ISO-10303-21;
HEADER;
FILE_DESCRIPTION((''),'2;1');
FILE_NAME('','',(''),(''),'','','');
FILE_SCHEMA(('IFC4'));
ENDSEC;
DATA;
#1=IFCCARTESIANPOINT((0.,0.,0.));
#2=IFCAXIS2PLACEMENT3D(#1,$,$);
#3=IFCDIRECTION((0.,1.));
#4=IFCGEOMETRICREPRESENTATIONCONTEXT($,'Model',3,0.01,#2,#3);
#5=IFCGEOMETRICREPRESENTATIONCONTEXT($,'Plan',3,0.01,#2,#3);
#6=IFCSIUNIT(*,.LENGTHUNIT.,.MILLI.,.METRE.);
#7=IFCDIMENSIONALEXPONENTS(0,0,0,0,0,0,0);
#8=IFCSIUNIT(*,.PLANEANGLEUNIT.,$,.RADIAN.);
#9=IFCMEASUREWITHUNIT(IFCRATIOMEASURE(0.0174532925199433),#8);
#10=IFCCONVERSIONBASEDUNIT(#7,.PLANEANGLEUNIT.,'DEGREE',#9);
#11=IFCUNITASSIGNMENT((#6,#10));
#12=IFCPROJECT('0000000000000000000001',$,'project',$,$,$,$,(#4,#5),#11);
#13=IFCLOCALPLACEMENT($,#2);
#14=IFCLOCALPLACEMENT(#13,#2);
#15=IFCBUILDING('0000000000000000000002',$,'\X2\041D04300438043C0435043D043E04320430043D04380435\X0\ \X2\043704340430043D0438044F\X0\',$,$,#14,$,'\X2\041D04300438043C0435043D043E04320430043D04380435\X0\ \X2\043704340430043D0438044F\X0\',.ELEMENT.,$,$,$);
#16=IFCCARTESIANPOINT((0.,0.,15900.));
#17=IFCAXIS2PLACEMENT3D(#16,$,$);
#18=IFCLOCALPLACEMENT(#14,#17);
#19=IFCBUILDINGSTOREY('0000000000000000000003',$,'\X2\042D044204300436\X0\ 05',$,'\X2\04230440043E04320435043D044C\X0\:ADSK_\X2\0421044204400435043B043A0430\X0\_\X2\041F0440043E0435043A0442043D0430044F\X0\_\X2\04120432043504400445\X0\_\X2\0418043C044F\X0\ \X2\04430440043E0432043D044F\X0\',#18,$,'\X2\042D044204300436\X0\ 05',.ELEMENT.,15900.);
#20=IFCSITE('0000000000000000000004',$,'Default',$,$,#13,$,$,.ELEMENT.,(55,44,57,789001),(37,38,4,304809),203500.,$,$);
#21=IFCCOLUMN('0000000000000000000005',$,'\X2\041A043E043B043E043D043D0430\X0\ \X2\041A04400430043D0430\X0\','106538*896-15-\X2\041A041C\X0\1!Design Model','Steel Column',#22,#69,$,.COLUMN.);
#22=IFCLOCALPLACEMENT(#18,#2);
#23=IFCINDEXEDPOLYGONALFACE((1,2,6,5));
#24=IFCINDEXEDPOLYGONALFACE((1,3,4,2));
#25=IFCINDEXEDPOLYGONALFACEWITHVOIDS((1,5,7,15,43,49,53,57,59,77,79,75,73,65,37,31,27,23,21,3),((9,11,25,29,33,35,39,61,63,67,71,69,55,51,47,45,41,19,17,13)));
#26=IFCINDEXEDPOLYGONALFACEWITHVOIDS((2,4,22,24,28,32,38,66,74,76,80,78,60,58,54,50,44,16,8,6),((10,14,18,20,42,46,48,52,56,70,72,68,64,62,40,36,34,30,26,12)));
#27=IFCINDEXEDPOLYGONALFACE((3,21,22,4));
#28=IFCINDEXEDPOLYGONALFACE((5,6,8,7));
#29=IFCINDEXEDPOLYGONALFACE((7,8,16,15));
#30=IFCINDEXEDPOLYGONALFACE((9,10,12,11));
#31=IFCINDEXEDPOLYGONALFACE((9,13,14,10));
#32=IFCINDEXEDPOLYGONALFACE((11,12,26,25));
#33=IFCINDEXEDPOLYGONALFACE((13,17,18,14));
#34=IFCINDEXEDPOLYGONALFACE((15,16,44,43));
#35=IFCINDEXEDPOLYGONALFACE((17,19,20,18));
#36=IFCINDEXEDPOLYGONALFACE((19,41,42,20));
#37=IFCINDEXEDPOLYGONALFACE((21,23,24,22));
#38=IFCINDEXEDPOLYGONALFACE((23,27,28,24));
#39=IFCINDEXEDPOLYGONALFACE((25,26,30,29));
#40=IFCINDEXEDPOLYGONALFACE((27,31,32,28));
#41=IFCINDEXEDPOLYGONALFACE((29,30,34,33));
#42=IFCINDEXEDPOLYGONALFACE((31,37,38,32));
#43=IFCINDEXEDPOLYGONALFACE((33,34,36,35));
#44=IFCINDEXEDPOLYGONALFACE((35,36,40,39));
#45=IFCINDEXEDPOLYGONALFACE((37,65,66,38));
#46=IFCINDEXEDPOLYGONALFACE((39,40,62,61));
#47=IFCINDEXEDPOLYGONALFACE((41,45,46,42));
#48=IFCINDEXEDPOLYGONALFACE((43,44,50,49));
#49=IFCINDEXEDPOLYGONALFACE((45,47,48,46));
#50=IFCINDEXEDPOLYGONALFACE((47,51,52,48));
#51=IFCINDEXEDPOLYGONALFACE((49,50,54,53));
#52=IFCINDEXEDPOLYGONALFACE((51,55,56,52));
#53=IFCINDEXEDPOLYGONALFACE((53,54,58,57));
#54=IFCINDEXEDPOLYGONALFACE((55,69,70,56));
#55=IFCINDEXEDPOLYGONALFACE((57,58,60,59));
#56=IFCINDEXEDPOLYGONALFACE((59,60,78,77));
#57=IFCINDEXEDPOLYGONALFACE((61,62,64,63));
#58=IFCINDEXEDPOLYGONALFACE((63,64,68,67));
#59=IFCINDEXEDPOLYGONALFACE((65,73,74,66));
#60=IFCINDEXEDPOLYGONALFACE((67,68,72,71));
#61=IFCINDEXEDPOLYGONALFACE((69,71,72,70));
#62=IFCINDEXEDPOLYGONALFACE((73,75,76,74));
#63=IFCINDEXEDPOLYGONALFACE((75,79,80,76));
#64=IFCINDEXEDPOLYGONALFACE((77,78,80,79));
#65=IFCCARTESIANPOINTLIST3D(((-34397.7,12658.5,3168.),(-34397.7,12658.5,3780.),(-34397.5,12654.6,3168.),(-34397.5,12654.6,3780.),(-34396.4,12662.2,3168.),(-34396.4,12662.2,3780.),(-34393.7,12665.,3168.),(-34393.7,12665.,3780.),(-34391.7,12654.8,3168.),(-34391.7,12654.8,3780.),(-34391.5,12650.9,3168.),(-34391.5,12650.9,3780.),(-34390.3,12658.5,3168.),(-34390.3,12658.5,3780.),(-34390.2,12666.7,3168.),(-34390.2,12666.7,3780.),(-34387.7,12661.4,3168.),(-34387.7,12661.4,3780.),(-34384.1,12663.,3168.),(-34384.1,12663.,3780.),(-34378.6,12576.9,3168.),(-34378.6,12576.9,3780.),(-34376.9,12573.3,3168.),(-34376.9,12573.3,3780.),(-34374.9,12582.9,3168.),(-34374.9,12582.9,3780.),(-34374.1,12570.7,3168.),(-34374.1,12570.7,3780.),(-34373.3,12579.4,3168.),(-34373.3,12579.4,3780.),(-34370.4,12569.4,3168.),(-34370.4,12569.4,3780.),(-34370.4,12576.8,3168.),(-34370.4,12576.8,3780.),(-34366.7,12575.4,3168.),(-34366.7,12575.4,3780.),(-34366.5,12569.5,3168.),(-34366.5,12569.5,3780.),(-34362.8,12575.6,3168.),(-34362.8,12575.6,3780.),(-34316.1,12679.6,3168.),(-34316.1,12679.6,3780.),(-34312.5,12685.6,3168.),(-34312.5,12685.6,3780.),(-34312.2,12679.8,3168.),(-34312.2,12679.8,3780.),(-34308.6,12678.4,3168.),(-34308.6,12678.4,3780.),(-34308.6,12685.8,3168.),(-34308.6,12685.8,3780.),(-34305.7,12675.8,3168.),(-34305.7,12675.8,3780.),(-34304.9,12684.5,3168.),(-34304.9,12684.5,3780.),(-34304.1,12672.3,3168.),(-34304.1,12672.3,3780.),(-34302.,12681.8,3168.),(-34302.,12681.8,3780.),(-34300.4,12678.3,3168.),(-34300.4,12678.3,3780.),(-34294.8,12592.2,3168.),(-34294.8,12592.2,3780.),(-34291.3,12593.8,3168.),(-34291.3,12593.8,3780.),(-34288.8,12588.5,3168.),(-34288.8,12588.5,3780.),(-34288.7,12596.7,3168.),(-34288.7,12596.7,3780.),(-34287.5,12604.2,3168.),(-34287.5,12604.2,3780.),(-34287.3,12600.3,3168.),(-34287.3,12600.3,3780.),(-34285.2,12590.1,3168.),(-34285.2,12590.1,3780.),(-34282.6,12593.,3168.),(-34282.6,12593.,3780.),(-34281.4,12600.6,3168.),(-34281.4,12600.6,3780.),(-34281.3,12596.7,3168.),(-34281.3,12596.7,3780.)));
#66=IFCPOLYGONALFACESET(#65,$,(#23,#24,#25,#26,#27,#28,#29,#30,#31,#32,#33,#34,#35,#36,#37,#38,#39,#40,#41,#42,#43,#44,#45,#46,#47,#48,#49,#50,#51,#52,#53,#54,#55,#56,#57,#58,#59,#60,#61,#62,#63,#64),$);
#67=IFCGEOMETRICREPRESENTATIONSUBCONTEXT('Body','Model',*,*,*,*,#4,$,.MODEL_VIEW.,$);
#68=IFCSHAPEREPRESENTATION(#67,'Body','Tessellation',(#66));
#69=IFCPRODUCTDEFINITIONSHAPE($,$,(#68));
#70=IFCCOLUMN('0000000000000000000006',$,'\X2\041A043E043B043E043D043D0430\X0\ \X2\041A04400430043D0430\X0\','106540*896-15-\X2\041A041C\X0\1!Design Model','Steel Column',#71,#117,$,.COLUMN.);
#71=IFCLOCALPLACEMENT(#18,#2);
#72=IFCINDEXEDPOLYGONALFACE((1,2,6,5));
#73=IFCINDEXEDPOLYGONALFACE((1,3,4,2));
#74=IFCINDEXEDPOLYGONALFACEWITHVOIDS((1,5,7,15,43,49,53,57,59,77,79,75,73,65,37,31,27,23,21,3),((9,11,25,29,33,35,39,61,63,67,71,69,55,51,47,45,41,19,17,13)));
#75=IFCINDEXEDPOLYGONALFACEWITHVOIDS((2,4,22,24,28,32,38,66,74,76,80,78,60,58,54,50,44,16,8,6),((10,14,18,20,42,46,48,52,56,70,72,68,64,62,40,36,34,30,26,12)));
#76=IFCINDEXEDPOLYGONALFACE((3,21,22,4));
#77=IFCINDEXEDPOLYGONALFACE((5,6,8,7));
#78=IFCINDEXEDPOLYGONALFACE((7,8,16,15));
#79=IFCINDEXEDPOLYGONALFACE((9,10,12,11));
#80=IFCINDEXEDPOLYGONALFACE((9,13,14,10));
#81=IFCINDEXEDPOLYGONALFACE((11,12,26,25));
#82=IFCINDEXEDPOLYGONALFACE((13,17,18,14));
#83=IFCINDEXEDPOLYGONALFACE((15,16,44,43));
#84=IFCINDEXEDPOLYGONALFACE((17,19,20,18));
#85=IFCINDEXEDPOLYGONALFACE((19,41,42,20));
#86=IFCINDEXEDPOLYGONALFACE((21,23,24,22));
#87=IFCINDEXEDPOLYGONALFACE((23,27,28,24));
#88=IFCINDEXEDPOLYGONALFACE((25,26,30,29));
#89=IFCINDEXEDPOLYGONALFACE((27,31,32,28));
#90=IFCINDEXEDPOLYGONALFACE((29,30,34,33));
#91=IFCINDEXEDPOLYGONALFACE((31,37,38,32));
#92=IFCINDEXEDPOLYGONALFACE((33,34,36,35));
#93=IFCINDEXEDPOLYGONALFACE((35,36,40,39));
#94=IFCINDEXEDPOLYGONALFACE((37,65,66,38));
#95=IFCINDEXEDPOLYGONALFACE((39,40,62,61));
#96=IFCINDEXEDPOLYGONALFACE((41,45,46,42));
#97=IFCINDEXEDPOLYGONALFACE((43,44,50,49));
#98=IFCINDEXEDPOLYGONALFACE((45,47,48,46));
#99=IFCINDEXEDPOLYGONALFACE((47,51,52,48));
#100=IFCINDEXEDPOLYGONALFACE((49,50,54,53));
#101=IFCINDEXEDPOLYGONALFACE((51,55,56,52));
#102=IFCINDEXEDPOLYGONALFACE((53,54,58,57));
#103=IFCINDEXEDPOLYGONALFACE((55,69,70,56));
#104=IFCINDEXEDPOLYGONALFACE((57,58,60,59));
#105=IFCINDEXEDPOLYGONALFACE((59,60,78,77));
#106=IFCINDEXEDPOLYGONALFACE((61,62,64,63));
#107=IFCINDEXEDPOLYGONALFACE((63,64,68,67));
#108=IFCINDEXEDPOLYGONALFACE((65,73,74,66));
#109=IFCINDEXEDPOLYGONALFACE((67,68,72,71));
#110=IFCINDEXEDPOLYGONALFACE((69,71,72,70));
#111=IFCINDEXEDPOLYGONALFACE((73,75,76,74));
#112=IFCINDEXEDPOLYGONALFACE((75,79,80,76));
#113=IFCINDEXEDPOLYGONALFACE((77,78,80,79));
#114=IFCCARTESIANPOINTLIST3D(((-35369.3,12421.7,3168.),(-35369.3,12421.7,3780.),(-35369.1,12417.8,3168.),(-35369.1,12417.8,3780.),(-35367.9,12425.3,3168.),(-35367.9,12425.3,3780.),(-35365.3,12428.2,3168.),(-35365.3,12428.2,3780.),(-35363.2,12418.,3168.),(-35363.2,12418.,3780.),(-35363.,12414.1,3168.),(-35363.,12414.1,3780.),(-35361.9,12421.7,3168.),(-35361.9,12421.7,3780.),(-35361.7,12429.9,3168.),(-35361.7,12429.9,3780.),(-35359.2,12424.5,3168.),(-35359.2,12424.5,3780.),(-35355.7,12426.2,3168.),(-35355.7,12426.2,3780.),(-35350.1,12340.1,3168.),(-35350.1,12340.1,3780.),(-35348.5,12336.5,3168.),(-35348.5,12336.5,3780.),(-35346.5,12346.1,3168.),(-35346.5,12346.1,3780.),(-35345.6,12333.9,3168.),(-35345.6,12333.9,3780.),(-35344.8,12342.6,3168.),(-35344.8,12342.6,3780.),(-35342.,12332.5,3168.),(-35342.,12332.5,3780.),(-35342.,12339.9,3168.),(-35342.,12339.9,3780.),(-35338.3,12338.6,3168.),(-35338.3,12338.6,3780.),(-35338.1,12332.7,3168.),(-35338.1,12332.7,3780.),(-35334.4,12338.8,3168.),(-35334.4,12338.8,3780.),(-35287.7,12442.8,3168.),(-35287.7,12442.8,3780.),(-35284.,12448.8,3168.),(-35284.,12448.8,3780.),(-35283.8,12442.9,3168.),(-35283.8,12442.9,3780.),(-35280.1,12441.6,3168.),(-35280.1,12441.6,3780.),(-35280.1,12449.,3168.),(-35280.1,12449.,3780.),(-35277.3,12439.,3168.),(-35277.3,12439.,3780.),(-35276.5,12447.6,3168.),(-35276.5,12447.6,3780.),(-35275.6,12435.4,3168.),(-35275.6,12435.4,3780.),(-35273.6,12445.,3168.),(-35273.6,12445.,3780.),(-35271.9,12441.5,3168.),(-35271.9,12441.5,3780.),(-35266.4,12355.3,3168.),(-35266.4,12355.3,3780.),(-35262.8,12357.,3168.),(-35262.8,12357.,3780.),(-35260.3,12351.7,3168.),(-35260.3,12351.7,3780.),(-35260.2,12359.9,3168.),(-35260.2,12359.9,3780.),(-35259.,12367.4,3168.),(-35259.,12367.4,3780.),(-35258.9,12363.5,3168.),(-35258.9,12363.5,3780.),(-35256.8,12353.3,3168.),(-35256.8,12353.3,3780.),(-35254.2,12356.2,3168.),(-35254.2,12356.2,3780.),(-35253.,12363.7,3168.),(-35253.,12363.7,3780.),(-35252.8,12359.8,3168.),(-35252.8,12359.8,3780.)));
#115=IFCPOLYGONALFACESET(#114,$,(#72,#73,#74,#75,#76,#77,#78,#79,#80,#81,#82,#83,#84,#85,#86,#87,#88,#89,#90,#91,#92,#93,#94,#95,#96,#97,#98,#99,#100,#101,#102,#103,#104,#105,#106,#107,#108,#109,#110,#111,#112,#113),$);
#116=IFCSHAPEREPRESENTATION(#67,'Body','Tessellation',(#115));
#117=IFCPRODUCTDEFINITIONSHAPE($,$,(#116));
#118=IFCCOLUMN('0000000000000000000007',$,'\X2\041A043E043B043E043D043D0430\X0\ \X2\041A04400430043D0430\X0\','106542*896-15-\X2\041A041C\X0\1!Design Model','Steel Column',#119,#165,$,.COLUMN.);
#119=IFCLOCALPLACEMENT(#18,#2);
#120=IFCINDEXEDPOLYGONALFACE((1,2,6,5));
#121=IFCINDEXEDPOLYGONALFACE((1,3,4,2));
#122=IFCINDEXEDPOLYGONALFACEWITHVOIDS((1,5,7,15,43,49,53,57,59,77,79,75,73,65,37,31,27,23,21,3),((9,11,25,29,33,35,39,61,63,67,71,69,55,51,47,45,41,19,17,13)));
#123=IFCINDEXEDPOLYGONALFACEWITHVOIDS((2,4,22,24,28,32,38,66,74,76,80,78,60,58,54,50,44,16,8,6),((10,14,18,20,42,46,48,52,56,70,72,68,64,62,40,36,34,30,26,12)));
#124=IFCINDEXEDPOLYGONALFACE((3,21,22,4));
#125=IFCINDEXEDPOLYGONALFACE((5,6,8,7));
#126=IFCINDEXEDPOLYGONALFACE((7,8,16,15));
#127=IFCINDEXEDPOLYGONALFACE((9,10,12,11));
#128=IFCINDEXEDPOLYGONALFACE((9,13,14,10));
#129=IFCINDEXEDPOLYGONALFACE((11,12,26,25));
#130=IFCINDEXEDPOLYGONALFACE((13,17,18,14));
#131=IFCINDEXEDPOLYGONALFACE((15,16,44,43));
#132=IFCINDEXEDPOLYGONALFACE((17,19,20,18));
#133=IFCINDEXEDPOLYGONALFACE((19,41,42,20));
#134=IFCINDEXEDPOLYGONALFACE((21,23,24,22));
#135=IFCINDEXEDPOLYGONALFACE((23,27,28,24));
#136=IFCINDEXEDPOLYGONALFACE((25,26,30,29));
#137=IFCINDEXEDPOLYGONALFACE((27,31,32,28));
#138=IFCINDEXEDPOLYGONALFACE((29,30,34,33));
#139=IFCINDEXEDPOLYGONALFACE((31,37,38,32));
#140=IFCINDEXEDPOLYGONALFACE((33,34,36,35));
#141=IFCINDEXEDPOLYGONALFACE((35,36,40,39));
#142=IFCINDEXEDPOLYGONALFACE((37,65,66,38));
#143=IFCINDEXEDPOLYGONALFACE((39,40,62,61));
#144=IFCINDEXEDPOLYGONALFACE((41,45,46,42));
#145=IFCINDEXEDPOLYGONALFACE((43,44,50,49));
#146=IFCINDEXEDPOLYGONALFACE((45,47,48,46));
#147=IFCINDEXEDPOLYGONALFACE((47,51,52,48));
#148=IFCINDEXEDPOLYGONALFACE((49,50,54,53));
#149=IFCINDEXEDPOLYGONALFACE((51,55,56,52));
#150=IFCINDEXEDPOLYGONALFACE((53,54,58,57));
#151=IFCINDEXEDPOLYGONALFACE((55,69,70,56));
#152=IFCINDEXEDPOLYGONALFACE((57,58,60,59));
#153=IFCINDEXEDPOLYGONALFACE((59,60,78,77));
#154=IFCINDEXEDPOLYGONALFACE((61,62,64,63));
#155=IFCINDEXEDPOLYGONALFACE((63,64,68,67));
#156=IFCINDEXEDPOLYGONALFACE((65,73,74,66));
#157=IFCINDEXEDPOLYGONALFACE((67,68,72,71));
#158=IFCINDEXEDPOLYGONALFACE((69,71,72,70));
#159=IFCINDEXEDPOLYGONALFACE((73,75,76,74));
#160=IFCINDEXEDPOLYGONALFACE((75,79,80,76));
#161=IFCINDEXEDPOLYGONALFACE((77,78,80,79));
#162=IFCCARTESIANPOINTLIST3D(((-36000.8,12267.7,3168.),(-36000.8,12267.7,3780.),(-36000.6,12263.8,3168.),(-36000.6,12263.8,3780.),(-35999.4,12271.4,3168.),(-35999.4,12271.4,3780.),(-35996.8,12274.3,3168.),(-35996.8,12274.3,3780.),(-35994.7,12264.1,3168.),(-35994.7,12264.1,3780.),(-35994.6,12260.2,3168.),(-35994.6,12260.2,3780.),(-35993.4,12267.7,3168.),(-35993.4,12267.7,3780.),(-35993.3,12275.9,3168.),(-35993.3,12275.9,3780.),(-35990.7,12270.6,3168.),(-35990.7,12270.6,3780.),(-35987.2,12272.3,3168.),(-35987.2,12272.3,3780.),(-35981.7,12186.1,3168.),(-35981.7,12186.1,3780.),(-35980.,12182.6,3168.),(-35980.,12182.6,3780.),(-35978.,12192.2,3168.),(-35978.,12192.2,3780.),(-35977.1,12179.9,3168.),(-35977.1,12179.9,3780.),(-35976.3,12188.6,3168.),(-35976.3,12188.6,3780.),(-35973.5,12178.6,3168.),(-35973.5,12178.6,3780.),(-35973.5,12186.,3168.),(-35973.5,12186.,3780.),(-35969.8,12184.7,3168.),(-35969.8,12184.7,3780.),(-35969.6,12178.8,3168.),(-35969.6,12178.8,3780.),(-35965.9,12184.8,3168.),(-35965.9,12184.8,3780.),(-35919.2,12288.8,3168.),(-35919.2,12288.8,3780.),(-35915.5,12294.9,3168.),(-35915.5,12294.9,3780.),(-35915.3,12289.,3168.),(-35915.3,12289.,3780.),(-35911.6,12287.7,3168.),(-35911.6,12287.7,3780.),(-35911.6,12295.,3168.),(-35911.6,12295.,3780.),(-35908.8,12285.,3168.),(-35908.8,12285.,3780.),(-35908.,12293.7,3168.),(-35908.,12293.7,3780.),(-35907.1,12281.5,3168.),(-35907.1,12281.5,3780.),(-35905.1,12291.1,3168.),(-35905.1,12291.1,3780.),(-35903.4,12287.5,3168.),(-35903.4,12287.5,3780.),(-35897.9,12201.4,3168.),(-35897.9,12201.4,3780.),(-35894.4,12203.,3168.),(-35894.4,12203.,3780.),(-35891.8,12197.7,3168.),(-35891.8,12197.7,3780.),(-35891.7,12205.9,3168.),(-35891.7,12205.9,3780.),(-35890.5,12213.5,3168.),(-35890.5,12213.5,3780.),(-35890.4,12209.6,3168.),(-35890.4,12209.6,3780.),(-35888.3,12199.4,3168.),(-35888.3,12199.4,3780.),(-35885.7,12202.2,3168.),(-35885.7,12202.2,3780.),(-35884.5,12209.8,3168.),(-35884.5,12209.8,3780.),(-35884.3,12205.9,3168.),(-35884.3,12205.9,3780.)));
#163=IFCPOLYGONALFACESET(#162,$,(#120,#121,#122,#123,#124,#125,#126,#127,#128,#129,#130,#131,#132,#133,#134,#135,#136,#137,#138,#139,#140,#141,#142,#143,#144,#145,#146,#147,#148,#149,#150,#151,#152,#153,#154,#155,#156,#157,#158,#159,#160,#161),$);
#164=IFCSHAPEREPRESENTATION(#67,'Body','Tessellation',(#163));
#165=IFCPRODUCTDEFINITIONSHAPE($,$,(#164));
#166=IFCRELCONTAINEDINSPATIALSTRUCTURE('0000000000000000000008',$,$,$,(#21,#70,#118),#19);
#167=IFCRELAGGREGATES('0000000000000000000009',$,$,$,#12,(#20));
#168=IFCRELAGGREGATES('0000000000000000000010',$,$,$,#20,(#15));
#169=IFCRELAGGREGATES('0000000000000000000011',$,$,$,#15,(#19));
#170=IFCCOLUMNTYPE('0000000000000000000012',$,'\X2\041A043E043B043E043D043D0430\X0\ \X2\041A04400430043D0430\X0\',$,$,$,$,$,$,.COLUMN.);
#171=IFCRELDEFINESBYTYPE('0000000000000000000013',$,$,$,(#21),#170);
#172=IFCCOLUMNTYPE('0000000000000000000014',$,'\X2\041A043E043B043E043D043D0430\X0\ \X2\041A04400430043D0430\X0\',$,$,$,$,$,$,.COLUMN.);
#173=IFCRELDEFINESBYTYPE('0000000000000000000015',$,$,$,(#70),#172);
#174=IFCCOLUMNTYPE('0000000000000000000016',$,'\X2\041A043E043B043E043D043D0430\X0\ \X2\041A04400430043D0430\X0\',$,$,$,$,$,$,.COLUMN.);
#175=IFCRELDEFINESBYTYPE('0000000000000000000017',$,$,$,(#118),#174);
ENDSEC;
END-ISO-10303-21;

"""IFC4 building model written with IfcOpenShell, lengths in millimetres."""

from ifc_helpers import new_model, entity, si_unit, converted_unit, direction, frame, origin, place, context, subcontext, project, spatial, indexed_curve, outline, extrude, type_object, element, save


model = new_model("IFC4")

# Units and contexts
model_context = context("Model", 3, precision=0.01, world=origin(), true_north=direction((0.0, 1.0)))
plan_context = context("Plan", 3, precision=0.01, world=origin(), true_north=direction((0.0, 1.0)))
body_context = subcontext(model_context, "Body", "Model", "MODEL_VIEW")
ifc_project = project(units=[si_unit("LENGTHUNIT", "METRE", prefix="MILLI"), converted_unit("PLANEANGLEUNIT", "DEGREE", entity("IfcRatioMeasure", 0.0174532925199433), si_unit("PLANEANGLEUNIT", "RADIAN"), dimensions=[0, 0, 0, 0, 0, 0, 0])], contexts=[model_context, plan_context])

# Site, building, storey
site_placement = place(None, origin())
site = spatial("IfcSite", under=ifc_project, at=site_placement, Name="Default", CompositionType="ELEMENT", RefLatitude=(55, 44, 57, 789001), RefLongitude=(37, 38, 4, 304809), RefElevation=203500.0)
building_placement = place(site_placement, origin())
building = spatial("IfcBuilding", under=site, at=building_placement, Name="Наименование здания", LongName="Наименование здания", CompositionType="ELEMENT")
storey_placement = place(building_placement, frame((0.0, 0.0, 15900.0)))
storey = spatial("IfcBuildingStorey", under=building, at=storey_placement, Name="Этаж 05", ObjectType="Уровень:ADSK_Стрелка_Проектная_Вверх_Имя уровня", LongName="Этаж 05", CompositionType="ELEMENT", Elevation=15900.0)

# Columns
column_type_1 = type_object("IfcColumnType", Name="Колонна Крана", PredefinedType="COLUMN")
column_1_placement = place(storey_placement, origin())
element("IfcColumn", 1, at=column_1_placement, inside=storey, type_object=column_type_1, Name="Колонна Крана", Description="106538*896-15-КМ1!Design Model", ObjectType="Steel Column", PredefinedType="COLUMN", context=body_context, shape_type="SweptSolid", body=[
    extrude(outline(indexed_curve([(29.5, -56.8), (33.4, -56.8), (37.0, -55.3), (39.7, -52.6), (41.2, -49.0), (56.8, 29.5), (56.8, 33.4), (55.3, 37.0), (52.6, 39.7), (49.0, 41.2), (-29.5, 56.8), (-33.4, 56.8), (-37.0, 55.3), (-39.7, 52.6), (-41.2, 49.0), (-56.8, -29.5), (-56.8, -33.4), (-55.3, -37.0), (-52.6, -39.7), (-49.0, -41.2), (29.5, -56.8)], self_intersect=False), holes=[indexed_curve([(-43.1, -37.3), (-46.7, -35.8), (-49.5, -33.1), (-51.0, -29.5), (-51.0, -25.5), (-37.3, 43.1), (-35.8, 46.7), (-33.1, 49.5), (-29.5, 51.0), (-25.5, 51.0), (43.1, 37.3), (46.7, 35.8), (49.5, 33.1), (51.0, 29.5), (51.0, 25.5), (37.3, -43.1), (35.8, -46.7), (33.1, -49.5), (29.5, -51.0), (25.5, -51.0), (-43.1, -37.3)], self_intersect=False)]), frame((-34339.5, 12627.6, 3168.0), z_axis=(0.0, 0.0, 1.0), x_axis=(0.906681, 0.421816, 0.0)), (0.0, 0.0, 1.0), 612.0),
])
column_type_2 = type_object("IfcColumnType", Name="Колонна Крана", PredefinedType="COLUMN")
column_2_placement = place(storey_placement, origin())
element("IfcColumn", 2, at=column_2_placement, inside=storey, type_object=column_type_2, Name="Колонна Крана", Description="106540*896-15-КМ1!Design Model", ObjectType="Steel Column", PredefinedType="COLUMN", context=body_context, shape_type="SweptSolid", body=[
    extrude(outline(indexed_curve([(29.5, -56.8), (33.4, -56.8), (37.0, -55.3), (39.7, -52.6), (41.2, -49.0), (56.8, 29.5), (56.8, 33.4), (55.3, 37.0), (52.6, 39.7), (49.0, 41.2), (-29.5, 56.8), (-33.4, 56.8), (-37.0, 55.3), (-39.7, 52.6), (-41.2, 49.0), (-56.8, -29.5), (-56.8, -33.4), (-55.3, -37.0), (-52.6, -39.7), (-49.0, -41.2), (29.5, -56.8)], self_intersect=False), holes=[indexed_curve([(-43.1, -37.3), (-46.7, -35.8), (-49.5, -33.1), (-51.0, -29.5), (-51.0, -25.5), (-37.3, 43.1), (-35.8, 46.7), (-33.1, 49.5), (-29.5, 51.0), (-25.5, 51.0), (43.1, 37.3), (46.7, 35.8), (49.5, 33.1), (51.0, 29.5), (51.0, 25.5), (37.3, -43.1), (35.8, -46.7), (33.1, -49.5), (29.5, -51.0), (25.5, -51.0), (-43.1, -37.3)], self_intersect=False)]), frame((-35311.0, 12390.8, 3168.0), z_axis=(0.0, 0.0, 1.0), x_axis=(0.906681, 0.421816, 0.0)), (0.0, 0.0, 1.0), 612.0),
])
column_type_3 = type_object("IfcColumnType", Name="Колонна Крана", PredefinedType="COLUMN")
column_3_placement = place(storey_placement, origin())
element("IfcColumn", 3, at=column_3_placement, inside=storey, type_object=column_type_3, Name="Колонна Крана", Description="106542*896-15-КМ1!Design Model", ObjectType="Steel Column", PredefinedType="COLUMN", context=body_context, shape_type="SweptSolid", body=[
    extrude(outline(indexed_curve([(29.5, -56.8), (33.4, -56.8), (37.0, -55.3), (39.7, -52.6), (41.2, -49.0), (56.8, 29.5), (56.8, 33.4), (55.3, 37.0), (52.6, 39.7), (49.0, 41.2), (-29.5, 56.8), (-33.4, 56.8), (-37.0, 55.3), (-39.7, 52.6), (-41.2, 49.0), (-56.8, -29.5), (-56.8, -33.4), (-55.3, -37.0), (-52.6, -39.7), (-49.0, -41.2), (29.5, -56.8)], self_intersect=False), holes=[indexed_curve([(-43.1, -37.3), (-46.7, -35.8), (-49.5, -33.1), (-51.0, -29.5), (-51.0, -25.5), (-37.3, 43.1), (-35.8, 46.7), (-33.1, 49.5), (-29.5, 51.0), (-25.5, 51.0), (43.1, 37.3), (46.7, 35.8), (49.5, 33.1), (51.0, 29.5), (51.0, 25.5), (37.3, -43.1), (35.8, -46.7), (33.1, -49.5), (29.5, -51.0), (25.5, -51.0), (-43.1, -37.3)], self_intersect=False)]), frame((-35942.5, 12236.8, 3168.0), z_axis=(0.0, 0.0, 1.0), x_axis=(0.906681, 0.421816, 0.0)), (0.0, 0.0, 1.0), 612.0),
])

save(model, "model.ifc")
